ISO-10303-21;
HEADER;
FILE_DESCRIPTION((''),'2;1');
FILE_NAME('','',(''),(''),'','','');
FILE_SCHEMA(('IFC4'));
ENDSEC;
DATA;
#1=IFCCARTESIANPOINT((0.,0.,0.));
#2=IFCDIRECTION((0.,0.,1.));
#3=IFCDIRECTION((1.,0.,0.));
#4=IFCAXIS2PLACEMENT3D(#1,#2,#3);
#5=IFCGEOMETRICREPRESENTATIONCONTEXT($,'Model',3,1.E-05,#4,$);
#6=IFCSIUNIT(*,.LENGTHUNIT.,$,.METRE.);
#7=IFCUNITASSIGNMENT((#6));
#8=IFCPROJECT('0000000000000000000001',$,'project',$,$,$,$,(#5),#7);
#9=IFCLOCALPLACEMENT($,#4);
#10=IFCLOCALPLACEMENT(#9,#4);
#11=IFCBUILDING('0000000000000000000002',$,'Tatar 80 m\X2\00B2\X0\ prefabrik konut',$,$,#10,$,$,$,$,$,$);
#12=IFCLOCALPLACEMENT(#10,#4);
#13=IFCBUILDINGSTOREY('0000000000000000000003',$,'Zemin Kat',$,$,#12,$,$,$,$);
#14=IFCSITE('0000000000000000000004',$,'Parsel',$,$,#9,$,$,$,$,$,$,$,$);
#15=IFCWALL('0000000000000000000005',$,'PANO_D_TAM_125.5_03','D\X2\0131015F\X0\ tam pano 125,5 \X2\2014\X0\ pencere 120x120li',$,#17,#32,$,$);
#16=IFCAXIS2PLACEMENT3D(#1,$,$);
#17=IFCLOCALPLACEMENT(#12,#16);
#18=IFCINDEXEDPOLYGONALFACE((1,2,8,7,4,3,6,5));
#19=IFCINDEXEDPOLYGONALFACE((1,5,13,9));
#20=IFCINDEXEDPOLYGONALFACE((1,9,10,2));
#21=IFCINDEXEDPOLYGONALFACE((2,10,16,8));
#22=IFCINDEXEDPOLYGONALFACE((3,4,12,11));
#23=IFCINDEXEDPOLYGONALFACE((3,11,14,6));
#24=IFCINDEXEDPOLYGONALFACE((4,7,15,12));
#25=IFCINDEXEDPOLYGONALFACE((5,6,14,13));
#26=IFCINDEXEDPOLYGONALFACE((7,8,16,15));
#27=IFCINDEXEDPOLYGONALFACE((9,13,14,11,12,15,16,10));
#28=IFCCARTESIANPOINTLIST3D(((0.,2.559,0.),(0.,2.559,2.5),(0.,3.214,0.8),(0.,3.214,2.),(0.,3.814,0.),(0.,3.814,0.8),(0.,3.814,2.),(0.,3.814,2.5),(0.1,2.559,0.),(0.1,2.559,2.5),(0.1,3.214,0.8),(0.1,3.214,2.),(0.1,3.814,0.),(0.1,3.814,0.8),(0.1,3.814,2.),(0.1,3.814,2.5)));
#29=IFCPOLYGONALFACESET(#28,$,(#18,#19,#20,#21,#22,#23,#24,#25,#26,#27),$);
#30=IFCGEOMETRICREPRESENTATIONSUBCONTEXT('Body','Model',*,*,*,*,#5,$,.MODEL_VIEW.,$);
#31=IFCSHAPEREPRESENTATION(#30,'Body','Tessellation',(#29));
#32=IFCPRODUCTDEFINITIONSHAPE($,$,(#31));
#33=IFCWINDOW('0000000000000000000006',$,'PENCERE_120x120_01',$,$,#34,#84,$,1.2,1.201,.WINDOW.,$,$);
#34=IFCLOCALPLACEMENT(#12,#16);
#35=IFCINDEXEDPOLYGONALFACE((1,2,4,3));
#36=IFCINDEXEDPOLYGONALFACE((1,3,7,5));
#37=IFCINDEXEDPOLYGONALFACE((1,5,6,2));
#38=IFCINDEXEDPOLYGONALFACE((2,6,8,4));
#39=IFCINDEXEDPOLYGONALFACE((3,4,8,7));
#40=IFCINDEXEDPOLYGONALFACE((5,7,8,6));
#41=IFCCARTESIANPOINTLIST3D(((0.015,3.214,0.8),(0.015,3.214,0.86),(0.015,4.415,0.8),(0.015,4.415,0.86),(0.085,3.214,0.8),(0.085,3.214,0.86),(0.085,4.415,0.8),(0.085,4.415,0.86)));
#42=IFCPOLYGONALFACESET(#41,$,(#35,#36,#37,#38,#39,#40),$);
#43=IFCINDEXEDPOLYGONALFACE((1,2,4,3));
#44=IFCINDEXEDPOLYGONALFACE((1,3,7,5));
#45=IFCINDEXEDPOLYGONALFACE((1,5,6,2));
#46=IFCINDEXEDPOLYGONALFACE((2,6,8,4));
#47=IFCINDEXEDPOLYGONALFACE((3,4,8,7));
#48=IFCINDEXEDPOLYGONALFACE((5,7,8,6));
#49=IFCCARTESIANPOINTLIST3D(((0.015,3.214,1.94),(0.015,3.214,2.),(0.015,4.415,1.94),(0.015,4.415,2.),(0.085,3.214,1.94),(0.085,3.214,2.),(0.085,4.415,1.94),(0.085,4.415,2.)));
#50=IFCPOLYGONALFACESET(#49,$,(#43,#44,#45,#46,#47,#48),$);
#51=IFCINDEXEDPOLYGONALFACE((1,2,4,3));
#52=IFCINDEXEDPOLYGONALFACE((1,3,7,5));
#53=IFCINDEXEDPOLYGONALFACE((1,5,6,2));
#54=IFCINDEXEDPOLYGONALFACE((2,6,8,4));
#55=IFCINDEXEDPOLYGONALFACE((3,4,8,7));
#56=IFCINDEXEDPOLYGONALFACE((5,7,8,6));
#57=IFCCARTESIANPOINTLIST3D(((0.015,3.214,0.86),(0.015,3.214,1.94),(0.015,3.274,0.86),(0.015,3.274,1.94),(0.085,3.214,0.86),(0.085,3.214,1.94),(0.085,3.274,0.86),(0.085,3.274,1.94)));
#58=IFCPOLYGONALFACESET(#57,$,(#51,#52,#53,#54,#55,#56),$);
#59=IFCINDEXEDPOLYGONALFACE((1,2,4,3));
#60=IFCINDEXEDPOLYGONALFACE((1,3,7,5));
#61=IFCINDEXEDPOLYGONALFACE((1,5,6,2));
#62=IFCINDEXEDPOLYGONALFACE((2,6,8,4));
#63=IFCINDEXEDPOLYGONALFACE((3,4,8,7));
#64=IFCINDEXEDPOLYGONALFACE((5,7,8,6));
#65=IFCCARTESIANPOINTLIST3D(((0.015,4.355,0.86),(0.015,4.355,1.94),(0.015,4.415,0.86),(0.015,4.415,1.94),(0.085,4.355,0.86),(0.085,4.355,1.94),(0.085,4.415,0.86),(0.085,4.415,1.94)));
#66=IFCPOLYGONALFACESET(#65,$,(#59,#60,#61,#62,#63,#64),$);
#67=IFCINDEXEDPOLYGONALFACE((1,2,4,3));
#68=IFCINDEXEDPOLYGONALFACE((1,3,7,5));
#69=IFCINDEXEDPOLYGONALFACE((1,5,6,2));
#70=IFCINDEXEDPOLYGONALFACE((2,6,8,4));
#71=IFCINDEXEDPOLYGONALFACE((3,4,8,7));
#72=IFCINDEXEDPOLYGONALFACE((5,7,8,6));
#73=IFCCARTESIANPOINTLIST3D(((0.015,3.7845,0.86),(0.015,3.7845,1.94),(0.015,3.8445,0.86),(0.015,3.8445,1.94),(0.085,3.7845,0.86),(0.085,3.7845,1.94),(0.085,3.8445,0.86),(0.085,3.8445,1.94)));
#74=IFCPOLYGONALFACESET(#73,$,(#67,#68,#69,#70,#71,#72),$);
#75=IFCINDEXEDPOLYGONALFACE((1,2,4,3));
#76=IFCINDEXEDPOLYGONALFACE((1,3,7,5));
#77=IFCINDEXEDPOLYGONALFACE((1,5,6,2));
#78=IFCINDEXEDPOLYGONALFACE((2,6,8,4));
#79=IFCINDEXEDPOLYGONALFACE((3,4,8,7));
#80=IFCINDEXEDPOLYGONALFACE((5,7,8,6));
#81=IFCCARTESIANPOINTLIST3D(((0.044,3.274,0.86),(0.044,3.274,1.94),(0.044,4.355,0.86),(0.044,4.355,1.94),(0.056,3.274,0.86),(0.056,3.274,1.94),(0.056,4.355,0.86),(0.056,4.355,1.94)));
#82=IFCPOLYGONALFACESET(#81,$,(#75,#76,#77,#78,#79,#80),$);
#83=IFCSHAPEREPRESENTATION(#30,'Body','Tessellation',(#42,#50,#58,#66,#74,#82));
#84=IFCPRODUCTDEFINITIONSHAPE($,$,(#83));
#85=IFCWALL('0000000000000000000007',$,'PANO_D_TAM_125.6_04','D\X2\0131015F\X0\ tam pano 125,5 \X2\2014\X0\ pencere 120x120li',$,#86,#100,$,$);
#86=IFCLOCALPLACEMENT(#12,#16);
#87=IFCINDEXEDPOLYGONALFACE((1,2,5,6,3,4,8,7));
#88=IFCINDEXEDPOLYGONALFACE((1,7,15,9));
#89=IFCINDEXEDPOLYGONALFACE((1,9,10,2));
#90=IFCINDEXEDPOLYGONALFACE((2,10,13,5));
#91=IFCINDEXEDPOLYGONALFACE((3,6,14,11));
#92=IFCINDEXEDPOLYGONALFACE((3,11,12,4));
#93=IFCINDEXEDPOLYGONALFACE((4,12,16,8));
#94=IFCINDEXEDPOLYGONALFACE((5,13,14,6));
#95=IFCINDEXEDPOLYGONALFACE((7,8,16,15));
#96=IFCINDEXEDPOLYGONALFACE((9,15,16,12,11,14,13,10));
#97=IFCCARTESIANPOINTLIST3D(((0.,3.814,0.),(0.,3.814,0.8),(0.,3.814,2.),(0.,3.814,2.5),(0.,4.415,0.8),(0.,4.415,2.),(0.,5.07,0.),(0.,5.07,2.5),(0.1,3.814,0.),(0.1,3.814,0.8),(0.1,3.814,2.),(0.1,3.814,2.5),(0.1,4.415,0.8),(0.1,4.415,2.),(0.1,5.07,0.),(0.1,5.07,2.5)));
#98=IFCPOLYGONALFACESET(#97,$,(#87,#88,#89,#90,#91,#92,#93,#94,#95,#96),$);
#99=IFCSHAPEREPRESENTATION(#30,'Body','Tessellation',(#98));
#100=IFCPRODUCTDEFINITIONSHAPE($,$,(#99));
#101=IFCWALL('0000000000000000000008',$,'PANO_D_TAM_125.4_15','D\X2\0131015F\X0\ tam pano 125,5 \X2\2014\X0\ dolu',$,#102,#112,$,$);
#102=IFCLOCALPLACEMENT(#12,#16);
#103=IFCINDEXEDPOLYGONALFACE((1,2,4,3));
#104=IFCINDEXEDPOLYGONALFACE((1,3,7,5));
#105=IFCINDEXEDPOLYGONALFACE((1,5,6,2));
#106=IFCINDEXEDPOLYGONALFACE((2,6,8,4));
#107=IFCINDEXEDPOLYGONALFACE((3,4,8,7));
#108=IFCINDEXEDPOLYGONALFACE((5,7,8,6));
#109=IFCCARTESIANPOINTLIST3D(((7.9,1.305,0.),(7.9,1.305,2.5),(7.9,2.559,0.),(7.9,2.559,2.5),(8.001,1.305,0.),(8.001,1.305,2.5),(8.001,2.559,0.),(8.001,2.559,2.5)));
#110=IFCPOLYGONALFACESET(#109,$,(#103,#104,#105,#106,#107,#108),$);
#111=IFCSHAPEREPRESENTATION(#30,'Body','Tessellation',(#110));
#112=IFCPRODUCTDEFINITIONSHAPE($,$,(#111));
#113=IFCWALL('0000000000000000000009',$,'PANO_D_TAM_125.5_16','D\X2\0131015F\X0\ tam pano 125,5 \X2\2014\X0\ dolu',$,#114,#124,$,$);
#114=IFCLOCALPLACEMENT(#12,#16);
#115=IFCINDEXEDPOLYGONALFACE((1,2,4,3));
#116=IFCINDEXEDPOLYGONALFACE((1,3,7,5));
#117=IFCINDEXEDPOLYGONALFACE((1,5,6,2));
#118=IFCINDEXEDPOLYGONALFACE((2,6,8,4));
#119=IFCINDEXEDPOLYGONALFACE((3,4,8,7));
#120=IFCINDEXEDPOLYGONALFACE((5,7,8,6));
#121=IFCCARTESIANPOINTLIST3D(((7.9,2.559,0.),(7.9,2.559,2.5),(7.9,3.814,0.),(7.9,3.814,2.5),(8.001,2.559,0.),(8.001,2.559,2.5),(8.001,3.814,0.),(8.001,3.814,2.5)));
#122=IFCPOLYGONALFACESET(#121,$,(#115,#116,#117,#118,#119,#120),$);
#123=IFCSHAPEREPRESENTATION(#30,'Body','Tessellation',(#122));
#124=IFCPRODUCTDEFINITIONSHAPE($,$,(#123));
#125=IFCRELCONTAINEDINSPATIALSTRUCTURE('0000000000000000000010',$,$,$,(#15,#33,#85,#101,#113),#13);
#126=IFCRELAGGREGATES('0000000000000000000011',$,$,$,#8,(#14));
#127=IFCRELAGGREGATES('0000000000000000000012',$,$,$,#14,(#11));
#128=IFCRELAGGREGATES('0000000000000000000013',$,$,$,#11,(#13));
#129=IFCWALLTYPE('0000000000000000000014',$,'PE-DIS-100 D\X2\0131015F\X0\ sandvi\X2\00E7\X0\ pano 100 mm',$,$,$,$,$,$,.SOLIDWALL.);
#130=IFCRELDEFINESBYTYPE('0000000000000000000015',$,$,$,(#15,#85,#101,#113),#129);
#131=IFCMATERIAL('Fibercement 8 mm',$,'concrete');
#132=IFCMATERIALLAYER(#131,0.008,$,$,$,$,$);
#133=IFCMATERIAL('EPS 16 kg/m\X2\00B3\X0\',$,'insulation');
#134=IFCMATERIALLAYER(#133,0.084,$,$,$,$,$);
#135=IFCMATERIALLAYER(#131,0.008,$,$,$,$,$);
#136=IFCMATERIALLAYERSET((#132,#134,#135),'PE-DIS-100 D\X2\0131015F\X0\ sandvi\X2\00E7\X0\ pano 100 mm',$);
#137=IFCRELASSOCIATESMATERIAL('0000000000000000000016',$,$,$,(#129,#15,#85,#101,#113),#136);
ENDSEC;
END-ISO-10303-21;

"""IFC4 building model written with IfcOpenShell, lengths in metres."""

from ifc_helpers import new_model, si_unit, frame, origin_with_axes, place, context, subcontext, project, spatial, line, indexed_curve, outline, extrude, material, layer, layer_set, layer_usage, type_object, element, fill, save


model = new_model("IFC4")

# Units and contexts
model_context = context("Model", 3, precision=1e-05, world=origin_with_axes())
body_context = subcontext(model_context, "Body", "Model", "MODEL_VIEW")
ifc_project = project(units=[si_unit("LENGTHUNIT", "METRE")], contexts=[model_context])

# Site, building, storey
site_placement = place(None, origin_with_axes())
site = spatial("IfcSite", under=ifc_project, at=site_placement, Name="Parsel")
building_placement = place(site_placement, origin_with_axes())
building = spatial("IfcBuilding", under=site, at=building_placement, Name="Tatar 80 m² prefabrik konut")
storey_placement = place(building_placement, origin_with_axes())
storey = spatial("IfcBuildingStorey", under=building, at=storey_placement, Name="Zemin Kat")

# Wall, opening, window
ifc_material_1 = material(Name="Fibercement 8 mm", Category="concrete")
ifc_layer_1 = layer(ifc_material_1, 0.008)
ifc_material_2 = material(Name="EPS 16 kg/m³", Category="insulation")
ifc_layer_2 = layer(ifc_material_2, 0.084)
ifc_layer_3 = layer(ifc_material_1, 0.008)
ifc_layer_set_1 = layer_set([ifc_layer_1, ifc_layer_2, ifc_layer_3], Name="PE-DIS-100 Dış sandviç pano 100 mm")
ifc_layer_usage_1 = layer_usage(ifc_layer_set_1, "AXIS2", "POSITIVE", 0.0)
wall_type_1 = type_object("IfcWallType", Name="PE-DIS-100 Dış sandviç pano 100 mm", PredefinedType="SOLIDWALL", material=ifc_layer_set_1)
wall_1_placement = place(storey_placement, frame((0.1, 2.559, 0.0), z_axis=(0.0, 0.0, 1.0), x_axis=(0.0, 1.0, 0.0)))
wall_1 = element("IfcWall", 1, at=wall_1_placement, inside=storey, type_object=wall_type_1, material=ifc_layer_usage_1, Name="PANO_D_TAM_125.5_03", Description="Dış tam pano 125,5 — pencere 120x120li", context=body_context, shape_type="SweptSolid", body=[
    extrude(outline(indexed_curve([(0.0, 0.0), (1.255, 0.0), (1.255, 0.1), (0.0, 0.1)], segments=[line(1, 2, 3, 4, 1)])), origin_with_axes(), (0.0, 0.0, 1.0), 2.5),
])
opening_1_placement = place(wall_1_placement, origin_with_axes())
opening_1 = element("IfcOpeningElement", 2, at=opening_1_placement, cuts=wall_1, PredefinedType="OPENING", context=body_context, shape_type="SweptSolid", body=[
    extrude(outline(indexed_curve([(0.0, 0.0), (0.6, 0.0), (0.6, 0.14), (0.0, 0.14)], segments=[line(1, 2, 3, 4, 1)])), frame((0.655, -0.02, 0.8), z_axis=(0.0, 0.0, 1.0), x_axis=(1.0, 0.0, 0.0)), (0.0, 0.0, 1.0), 1.2),
])
window_1_placement = place(storey_placement, frame((0.1, 2.559, 0.0), z_axis=(0.0, 0.0, 1.0), x_axis=(0.0, 1.0, 0.0)))
window_1 = element("IfcWindow", 3, at=window_1_placement, inside=storey, Name="PENCERE_120x120_01", OverallHeight=1.2, OverallWidth=1.201, PredefinedType="WINDOW", context=body_context, shape_type="SweptSolid", body=[
    extrude(outline(indexed_curve([(0.0, 0.0), (1.201, 0.0), (1.201, 0.07), (0.0, 0.07)], segments=[line(1, 2, 3, 4, 1)])), frame((0.655, 0.015, 0.8), z_axis=(0.0, 0.0, 1.0), x_axis=(1.0, 0.0, 0.0)), (0.0, 0.0, 1.0), 0.06),
    extrude(outline(indexed_curve([(0.0, 0.0), (1.201, 0.0), (1.201, 0.07), (0.0, 0.07)], segments=[line(1, 2, 3, 4, 1)])), frame((0.655, 0.015, 1.94), z_axis=(0.0, 0.0, 1.0), x_axis=(1.0, 0.0, 0.0)), (0.0, 0.0, 1.0), 0.06),
    extrude(outline(indexed_curve([(0.0, 0.0), (0.06, 0.0), (0.06, 0.07), (0.0, 0.07)], segments=[line(1, 2, 3, 4, 1)])), frame((0.655, 0.015, 0.86), z_axis=(0.0, 0.0, 1.0), x_axis=(1.0, 0.0, 0.0)), (0.0, 0.0, 1.0), 1.08),
    extrude(outline(indexed_curve([(0.0, 0.0), (0.06, 0.0), (0.06, 0.07), (0.0, 0.07)], segments=[line(1, 2, 3, 4, 1)])), frame((1.796, 0.015, 0.86), z_axis=(0.0, 0.0, 1.0), x_axis=(1.0, 0.0, 0.0)), (0.0, 0.0, 1.0), 1.08),
    extrude(outline(indexed_curve([(0.0, 0.0), (0.06, 0.0), (0.06, 0.07), (0.0, 0.07)], segments=[line(1, 2, 3, 4, 1)])), frame((1.2255, 0.015, 0.86), z_axis=(0.0, 0.0, 1.0), x_axis=(1.0, 0.0, 0.0)), (0.0, 0.0, 1.0), 1.08),
    extrude(outline(indexed_curve([(0.0, 0.0), (1.081, 0.0), (1.081, 0.012), (0.0, 0.012)], segments=[line(1, 2, 3, 4, 1)])), frame((0.715, 0.044, 0.86), z_axis=(0.0, 0.0, 1.0), x_axis=(1.0, 0.0, 0.0)), (0.0, 0.0, 1.0), 1.08),
])
fill(opening_1, window_1)

# Wall, opening
ifc_layer_usage_2 = layer_usage(ifc_layer_set_1, "AXIS2", "POSITIVE", 0.0)
wall_2_placement = place(storey_placement, frame((0.1, 3.814, 0.0), z_axis=(0.0, 0.0, 1.0), x_axis=(0.0, 1.0, 0.0)))
wall_2 = element("IfcWall", 4, at=wall_2_placement, inside=storey, type_object=wall_type_1, material=ifc_layer_usage_2, Name="PANO_D_TAM_125.6_04", Description="Dış tam pano 125,5 — pencere 120x120li", context=body_context, shape_type="SweptSolid", body=[
    extrude(outline(indexed_curve([(0.0, 0.0), (1.256, 0.0), (1.256, 0.1), (0.0, 0.1)], segments=[line(1, 2, 3, 4, 1)])), origin_with_axes(), (0.0, 0.0, 1.0), 2.5),
])
opening_2_placement = place(wall_2_placement, origin_with_axes())
element("IfcOpeningElement", 5, at=opening_2_placement, cuts=wall_2, PredefinedType="OPENING", context=body_context, shape_type="SweptSolid", body=[
    extrude(outline(indexed_curve([(0.0, 0.0), (0.601, 0.0), (0.601, 0.14), (0.0, 0.14)], segments=[line(1, 2, 3, 4, 1)])), frame((0.0, -0.02, 0.8), z_axis=(0.0, 0.0, 1.0), x_axis=(1.0, 0.0, 0.0)), (0.0, 0.0, 1.0), 1.2),
])

# Walls
ifc_layer_usage_3 = layer_usage(ifc_layer_set_1, "AXIS2", "POSITIVE", 0.0)
wall_3_placement = place(storey_placement, frame((8.001, 1.305, 0.0), z_axis=(0.0, 0.0, 1.0), x_axis=(0.0, 1.0, 0.0)))
element("IfcWall", 6, at=wall_3_placement, inside=storey, type_object=wall_type_1, material=ifc_layer_usage_3, Name="PANO_D_TAM_125.4_15", Description="Dış tam pano 125,5 — dolu", context=body_context, shape_type="SweptSolid", body=[
    extrude(outline(indexed_curve([(0.0, 0.0), (1.254, 0.0), (1.254, 0.101), (0.0, 0.101)], segments=[line(1, 2, 3, 4, 1)])), origin_with_axes(), (0.0, 0.0, 1.0), 2.5),
])
ifc_layer_usage_4 = layer_usage(ifc_layer_set_1, "AXIS2", "POSITIVE", 0.0)
wall_4_placement = place(storey_placement, frame((8.001, 2.559, 0.0), z_axis=(0.0, 0.0, 1.0), x_axis=(0.0, 1.0, 0.0)))
element("IfcWall", 7, at=wall_4_placement, inside=storey, type_object=wall_type_1, material=ifc_layer_usage_4, Name="PANO_D_TAM_125.5_16", Description="Dış tam pano 125,5 — dolu", context=body_context, shape_type="SweptSolid", body=[
    extrude(outline(indexed_curve([(0.0, 0.0), (1.255, 0.0), (1.255, 0.101), (0.0, 0.101)], segments=[line(1, 2, 3, 4, 1)])), origin_with_axes(), (0.0, 0.0, 1.0), 2.5),
])

save(model, "model.ifc")
